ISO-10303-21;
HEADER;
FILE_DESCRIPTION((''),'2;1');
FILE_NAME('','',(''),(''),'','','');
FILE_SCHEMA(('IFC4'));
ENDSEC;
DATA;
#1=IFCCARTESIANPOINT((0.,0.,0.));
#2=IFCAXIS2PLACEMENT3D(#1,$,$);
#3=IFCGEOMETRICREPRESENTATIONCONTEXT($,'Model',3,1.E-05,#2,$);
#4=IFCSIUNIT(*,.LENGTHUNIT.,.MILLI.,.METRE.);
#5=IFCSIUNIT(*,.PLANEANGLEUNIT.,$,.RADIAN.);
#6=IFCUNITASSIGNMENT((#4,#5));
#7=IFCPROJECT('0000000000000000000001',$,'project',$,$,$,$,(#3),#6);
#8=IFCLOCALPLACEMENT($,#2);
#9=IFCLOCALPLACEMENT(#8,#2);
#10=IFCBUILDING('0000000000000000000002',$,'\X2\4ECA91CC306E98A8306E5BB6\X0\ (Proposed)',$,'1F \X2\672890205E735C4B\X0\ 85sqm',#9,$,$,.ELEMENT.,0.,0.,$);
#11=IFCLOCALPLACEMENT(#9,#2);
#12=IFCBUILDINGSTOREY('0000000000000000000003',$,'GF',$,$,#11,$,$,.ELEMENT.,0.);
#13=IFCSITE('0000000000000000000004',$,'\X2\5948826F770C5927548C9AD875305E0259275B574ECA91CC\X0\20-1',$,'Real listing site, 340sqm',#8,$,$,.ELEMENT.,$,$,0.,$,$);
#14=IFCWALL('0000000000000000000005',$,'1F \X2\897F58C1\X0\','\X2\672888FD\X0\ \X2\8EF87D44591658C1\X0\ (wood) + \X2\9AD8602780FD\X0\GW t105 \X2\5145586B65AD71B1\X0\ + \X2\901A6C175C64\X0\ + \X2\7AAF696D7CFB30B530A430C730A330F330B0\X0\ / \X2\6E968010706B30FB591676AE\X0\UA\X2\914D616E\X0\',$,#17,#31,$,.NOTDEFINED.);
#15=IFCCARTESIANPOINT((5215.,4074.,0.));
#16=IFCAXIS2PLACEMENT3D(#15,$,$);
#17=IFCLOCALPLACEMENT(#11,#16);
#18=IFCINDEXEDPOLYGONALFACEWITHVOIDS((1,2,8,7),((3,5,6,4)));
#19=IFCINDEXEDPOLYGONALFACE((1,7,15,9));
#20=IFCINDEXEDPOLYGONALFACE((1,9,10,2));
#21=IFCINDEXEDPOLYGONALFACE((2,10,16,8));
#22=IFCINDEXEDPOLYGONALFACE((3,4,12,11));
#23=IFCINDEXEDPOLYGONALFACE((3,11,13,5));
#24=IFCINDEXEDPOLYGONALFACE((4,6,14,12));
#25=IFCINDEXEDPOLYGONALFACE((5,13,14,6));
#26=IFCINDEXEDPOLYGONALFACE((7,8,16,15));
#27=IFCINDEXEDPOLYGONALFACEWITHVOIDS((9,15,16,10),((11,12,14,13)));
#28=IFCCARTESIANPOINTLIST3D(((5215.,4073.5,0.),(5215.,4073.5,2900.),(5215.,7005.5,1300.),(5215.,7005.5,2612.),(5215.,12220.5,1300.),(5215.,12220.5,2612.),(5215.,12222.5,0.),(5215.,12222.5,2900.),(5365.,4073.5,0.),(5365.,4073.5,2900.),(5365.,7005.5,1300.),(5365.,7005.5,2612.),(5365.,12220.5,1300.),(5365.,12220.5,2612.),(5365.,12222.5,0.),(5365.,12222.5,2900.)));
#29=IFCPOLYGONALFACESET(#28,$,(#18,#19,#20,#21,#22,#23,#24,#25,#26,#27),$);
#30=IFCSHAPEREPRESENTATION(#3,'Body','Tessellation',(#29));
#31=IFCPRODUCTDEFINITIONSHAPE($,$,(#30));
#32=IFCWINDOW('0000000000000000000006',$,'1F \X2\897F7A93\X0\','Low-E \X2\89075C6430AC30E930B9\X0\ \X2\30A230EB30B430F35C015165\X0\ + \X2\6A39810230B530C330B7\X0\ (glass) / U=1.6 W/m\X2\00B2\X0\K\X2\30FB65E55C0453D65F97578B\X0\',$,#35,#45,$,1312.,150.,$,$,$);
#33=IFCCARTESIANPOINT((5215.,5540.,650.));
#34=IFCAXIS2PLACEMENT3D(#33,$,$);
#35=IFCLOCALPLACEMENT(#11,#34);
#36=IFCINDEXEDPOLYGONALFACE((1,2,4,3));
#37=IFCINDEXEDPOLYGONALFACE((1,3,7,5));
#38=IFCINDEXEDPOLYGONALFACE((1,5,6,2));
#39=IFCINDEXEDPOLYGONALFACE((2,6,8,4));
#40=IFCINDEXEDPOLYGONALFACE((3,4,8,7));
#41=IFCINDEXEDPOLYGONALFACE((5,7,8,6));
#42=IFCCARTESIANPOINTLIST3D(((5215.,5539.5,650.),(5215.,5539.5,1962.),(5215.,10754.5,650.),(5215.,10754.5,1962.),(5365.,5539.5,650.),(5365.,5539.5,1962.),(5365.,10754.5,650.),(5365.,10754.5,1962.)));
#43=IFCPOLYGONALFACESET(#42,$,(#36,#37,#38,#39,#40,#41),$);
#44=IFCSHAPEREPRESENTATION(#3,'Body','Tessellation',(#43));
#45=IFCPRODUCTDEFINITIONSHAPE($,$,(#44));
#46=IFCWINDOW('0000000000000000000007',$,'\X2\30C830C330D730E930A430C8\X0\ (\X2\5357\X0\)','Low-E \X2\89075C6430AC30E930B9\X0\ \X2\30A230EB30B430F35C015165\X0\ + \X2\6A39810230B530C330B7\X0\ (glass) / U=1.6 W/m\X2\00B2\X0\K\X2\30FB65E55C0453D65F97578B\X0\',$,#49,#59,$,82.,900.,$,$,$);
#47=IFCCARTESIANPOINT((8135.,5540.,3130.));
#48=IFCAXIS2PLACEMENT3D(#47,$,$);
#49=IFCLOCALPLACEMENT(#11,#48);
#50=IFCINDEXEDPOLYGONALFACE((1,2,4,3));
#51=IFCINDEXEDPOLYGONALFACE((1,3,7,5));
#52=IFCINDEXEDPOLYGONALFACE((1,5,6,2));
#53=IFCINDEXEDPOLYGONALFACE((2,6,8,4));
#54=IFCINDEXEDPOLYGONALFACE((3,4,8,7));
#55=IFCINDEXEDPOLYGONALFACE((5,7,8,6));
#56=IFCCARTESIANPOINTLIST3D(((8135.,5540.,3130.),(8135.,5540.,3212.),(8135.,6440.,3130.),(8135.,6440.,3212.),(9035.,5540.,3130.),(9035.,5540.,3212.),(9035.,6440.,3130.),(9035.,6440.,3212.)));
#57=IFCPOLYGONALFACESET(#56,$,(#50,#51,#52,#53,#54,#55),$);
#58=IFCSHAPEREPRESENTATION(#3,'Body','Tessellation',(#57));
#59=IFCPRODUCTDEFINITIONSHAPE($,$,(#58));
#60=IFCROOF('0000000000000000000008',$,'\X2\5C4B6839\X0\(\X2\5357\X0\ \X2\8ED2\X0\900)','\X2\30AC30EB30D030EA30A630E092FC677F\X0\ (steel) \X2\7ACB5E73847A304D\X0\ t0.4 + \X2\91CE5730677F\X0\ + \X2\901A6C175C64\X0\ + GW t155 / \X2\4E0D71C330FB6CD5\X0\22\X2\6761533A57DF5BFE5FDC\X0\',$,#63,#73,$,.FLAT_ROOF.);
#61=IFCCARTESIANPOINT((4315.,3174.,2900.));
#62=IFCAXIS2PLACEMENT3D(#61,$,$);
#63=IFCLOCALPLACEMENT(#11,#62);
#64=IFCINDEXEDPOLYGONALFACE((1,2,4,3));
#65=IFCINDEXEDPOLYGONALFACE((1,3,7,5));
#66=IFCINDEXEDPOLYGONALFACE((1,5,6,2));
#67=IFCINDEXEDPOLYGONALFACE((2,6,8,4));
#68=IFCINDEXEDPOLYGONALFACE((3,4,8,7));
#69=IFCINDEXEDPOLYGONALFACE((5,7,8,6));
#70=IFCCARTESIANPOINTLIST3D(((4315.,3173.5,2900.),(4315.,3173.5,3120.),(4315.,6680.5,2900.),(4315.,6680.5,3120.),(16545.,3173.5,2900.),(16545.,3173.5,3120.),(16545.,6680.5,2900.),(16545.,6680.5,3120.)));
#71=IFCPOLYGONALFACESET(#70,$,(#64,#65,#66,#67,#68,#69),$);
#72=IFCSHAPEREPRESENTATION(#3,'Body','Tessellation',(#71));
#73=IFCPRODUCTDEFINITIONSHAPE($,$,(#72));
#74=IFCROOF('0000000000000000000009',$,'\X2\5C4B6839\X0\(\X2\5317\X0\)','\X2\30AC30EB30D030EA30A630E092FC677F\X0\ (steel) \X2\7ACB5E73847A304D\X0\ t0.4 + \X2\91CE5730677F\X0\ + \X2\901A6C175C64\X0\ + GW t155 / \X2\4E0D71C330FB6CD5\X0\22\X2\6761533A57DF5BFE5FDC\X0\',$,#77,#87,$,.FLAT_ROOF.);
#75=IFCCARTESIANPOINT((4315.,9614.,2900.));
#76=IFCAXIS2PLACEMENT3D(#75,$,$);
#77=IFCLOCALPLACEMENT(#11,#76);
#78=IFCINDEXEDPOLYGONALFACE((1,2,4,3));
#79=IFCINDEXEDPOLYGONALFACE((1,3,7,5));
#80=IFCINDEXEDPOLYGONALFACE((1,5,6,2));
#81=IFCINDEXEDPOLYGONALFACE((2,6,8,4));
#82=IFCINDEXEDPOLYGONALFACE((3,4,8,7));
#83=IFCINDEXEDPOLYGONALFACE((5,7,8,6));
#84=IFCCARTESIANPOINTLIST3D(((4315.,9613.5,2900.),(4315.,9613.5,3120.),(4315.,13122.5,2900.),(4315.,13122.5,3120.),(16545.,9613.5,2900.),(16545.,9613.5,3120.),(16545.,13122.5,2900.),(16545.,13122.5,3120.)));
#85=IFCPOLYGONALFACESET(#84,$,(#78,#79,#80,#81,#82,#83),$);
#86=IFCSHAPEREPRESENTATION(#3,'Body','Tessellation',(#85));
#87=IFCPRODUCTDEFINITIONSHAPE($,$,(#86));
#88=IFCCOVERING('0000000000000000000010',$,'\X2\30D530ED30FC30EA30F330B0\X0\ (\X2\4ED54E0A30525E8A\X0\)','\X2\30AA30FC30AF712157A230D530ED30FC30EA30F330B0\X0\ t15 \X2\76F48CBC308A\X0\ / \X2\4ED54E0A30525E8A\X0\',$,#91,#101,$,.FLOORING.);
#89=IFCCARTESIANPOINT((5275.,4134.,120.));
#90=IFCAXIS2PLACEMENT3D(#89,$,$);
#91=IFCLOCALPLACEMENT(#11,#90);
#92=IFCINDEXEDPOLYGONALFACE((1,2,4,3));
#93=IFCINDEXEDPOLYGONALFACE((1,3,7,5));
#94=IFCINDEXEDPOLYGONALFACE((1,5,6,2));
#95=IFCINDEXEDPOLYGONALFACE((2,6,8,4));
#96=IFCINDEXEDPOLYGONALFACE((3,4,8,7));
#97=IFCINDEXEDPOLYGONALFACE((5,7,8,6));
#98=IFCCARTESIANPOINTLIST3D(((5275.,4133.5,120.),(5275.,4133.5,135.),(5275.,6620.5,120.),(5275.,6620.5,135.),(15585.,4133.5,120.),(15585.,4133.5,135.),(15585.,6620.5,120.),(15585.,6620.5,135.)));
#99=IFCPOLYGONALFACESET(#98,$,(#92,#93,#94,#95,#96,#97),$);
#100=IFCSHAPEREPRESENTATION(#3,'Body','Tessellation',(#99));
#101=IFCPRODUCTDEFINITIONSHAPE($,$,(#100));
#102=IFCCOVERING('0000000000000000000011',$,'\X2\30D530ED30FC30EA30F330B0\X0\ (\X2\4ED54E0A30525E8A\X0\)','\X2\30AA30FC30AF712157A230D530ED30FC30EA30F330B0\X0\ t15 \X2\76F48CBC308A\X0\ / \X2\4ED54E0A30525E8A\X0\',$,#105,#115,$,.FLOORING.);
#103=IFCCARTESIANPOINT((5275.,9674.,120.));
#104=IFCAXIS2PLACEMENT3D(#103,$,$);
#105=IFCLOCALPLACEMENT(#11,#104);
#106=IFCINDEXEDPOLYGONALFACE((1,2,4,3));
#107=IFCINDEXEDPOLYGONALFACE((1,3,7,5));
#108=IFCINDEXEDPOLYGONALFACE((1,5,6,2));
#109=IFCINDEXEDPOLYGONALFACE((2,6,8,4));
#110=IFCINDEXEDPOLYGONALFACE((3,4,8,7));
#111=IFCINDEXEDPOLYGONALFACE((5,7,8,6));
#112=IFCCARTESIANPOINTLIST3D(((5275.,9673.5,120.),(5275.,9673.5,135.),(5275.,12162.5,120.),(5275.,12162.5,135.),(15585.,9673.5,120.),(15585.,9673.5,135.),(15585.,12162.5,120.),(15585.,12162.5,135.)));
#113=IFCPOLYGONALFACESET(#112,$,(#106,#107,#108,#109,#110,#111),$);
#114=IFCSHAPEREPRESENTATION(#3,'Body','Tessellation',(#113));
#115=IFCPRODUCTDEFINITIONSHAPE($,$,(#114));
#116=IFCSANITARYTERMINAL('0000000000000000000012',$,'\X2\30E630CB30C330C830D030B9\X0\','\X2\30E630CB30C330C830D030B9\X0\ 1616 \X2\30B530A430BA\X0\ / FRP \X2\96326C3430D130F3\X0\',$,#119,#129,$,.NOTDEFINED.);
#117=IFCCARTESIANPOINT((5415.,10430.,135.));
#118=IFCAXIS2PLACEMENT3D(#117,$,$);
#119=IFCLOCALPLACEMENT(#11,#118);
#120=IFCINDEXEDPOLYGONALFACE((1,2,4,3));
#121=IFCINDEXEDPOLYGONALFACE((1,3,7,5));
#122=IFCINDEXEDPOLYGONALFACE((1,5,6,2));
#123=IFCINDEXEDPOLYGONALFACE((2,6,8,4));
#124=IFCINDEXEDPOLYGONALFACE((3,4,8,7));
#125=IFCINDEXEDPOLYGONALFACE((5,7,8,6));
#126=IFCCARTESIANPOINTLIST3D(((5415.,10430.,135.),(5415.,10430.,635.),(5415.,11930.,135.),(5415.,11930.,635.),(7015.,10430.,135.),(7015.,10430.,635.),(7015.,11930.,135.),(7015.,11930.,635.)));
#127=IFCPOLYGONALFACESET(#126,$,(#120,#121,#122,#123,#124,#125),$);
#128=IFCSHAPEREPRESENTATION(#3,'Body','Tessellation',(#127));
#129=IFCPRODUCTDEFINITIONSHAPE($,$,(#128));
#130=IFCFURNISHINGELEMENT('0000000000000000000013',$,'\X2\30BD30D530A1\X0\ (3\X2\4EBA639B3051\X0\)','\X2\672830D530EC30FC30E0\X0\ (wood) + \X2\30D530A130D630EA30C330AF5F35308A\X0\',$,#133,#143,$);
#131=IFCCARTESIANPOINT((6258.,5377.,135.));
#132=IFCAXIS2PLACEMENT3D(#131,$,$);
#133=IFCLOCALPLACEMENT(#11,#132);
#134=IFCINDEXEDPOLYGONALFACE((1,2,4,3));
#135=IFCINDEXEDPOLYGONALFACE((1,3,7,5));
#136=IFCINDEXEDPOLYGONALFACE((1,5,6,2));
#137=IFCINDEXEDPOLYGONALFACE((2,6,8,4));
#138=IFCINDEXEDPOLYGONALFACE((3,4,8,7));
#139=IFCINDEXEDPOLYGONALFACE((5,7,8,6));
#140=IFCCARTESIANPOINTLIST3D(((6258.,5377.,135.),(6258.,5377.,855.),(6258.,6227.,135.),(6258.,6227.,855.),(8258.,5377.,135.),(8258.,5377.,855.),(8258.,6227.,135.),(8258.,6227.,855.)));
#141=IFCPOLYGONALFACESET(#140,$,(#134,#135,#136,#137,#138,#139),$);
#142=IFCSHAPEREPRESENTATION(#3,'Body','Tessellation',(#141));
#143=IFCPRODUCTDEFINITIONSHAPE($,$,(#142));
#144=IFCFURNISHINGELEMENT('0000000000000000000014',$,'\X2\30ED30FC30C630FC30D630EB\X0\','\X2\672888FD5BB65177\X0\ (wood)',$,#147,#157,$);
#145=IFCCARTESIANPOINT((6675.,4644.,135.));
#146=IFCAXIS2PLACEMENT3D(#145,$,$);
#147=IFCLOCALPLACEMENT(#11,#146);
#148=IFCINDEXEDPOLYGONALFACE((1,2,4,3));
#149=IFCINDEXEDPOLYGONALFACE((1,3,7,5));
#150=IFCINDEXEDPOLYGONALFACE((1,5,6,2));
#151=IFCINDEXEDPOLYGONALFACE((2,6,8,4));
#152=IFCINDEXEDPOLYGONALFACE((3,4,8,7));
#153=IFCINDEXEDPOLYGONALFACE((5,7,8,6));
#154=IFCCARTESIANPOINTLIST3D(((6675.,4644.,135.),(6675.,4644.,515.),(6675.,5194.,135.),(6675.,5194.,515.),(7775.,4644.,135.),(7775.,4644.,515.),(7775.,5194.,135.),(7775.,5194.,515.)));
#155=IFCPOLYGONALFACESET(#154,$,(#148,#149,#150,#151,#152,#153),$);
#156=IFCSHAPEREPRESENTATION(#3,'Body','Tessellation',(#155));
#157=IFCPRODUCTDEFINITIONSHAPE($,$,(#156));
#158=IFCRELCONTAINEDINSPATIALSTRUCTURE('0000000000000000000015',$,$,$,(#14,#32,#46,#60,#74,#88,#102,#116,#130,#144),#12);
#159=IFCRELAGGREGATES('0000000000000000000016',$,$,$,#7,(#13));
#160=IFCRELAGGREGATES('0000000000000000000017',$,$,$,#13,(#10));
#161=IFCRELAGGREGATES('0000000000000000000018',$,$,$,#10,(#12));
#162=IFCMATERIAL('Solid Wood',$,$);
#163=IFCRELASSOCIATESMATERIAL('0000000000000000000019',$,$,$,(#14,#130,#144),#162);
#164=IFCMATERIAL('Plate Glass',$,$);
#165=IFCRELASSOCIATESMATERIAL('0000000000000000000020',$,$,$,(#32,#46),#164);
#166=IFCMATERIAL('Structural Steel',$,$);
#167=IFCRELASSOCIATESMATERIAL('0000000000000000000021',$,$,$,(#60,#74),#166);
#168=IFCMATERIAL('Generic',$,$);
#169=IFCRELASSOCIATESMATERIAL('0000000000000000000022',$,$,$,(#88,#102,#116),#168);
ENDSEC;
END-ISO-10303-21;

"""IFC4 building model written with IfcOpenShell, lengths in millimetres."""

from ifc_helpers import new_model, si_unit, frame, frame_2d, origin, place, context, project, spatial, rectangle, extrude, material, element, fill, save


model = new_model("IFC4")

# Units and contexts
model_context = context("Model", 3, precision=1e-05, world=origin())
ifc_project = project(units=[si_unit("LENGTHUNIT", "METRE", prefix="MILLI"), si_unit("PLANEANGLEUNIT", "RADIAN")], contexts=[model_context])

# Site, building, storey
site_placement = place(None, origin())
site = spatial("IfcSite", under=ifc_project, at=site_placement, Name="奈良県大和高田市大字今里20-1", ObjectType="Real listing site, 340sqm", CompositionType="ELEMENT", RefElevation=0.0)
building_placement = place(site_placement, origin())
building = spatial("IfcBuilding", under=site, at=building_placement, Name="今里の風の家 (Proposed)", ObjectType="1F 木造平屋 85sqm", CompositionType="ELEMENT", ElevationOfRefHeight=0.0, ElevationOfTerrain=0.0)
storey_placement = place(building_placement, origin())
storey = spatial("IfcBuildingStorey", under=building, at=storey_placement, Name="GF", CompositionType="ELEMENT", Elevation=0.0)

# Shared definitions
ifc_material_1 = material(Name="Solid Wood")

# Shared definitions
ifc_material_2 = material(Name="Plate Glass")

# Wall, opening, window
wall_1_placement = place(storey_placement, frame((5215.0, 4074.0, 0.0)))
wall_1 = element("IfcWall", 1, at=wall_1_placement, inside=storey, material=ifc_material_1, Name="1F 西壁", Description="木製 軸組外壁 (wood) + 高性能GW t105 充填断熱 + 通気層 + 窯業系サイディング / 準耐火・外皮UA配慮", PredefinedType="NOTDEFINED", context=model_context, shape_type="SweptSolid", body=[
    extrude(rectangle(XDim=150.0, YDim=8149.0, at=frame_2d((75.0, 4074.0))), frame((5215.0, 4074.0, 0.0)), (0.0, 0.0, 1.0), 2900.0),
])
opening_1_placement = place(storey_placement, frame((5215.0, 5540.0, 650.0)))
opening_1 = element("IfcOpeningElement", 2, at=opening_1_placement, cuts=wall_1, PredefinedType="NOTDEFINED", context=model_context, shape_type="SweptSolid", body=[
    extrude(rectangle(XDim=150.0, YDim=5215.0, at=frame_2d((75.0, 2607.0))), frame((5215.0, 5540.0, 650.0)), (0.0, 0.0, 1.0), 1312.0),
])
window_1_placement = place(storey_placement, frame((5215.0, 5540.0, 650.0)))
window_1 = element("IfcWindow", 3, at=window_1_placement, inside=storey, material=ifc_material_2, Name="1F 西窓", Description="Low-E 複層ガラス アルゴン封入 + 樹脂サッシ (glass) / U=1.6 W/m²K・日射取得型", OverallHeight=1312.0, OverallWidth=150.0, context=model_context, shape_type="SweptSolid", body=[
    extrude(rectangle(XDim=150.0, YDim=5215.0, at=frame_2d((75.0, 2607.0))), frame((5215.0, 5540.0, 650.0)), (0.0, 0.0, 1.0), 1312.0),
])
fill(opening_1, window_1)

# Window
window_2_placement = place(storey_placement, frame((8135.0, 5540.0, 3130.0)))
element("IfcWindow", 4, at=window_2_placement, inside=storey, material=ifc_material_2, Name="トップライト (南)", Description="Low-E 複層ガラス アルゴン封入 + 樹脂サッシ (glass) / U=1.6 W/m²K・日射取得型", OverallHeight=82.0, OverallWidth=900.0, context=model_context, shape_type="SweptSolid", body=[
    extrude(rectangle(XDim=900.0, YDim=900.0, at=frame_2d((450.0, 450.0))), frame((8135.0, 5540.0, 3130.0)), (0.0, 0.0, 1.0), 82.0),
])

# Roofs
ifc_material_3 = material(Name="Structural Steel")
roof_1_placement = place(storey_placement, frame((4315.0, 3174.0, 2900.0)))
element("IfcRoof", 5, at=roof_1_placement, inside=storey, material=ifc_material_3, Name="屋根(南 軒900)", Description="ガルバリウム鋼板 (steel) 立平葺き t0.4 + 野地板 + 通気層 + GW t155 / 不燃・法22条区域対応", PredefinedType="FLAT_ROOF", context=model_context, shape_type="SweptSolid", body=[
    extrude(rectangle(XDim=12230.0, YDim=3507.0, at=frame_2d((6115.0, 1753.0))), frame((4315.0, 3174.0, 2900.0)), (0.0, 0.0, 1.0), 220.0),
])
roof_2_placement = place(storey_placement, frame((4315.0, 9614.0, 2900.0)))
element("IfcRoof", 6, at=roof_2_placement, inside=storey, material=ifc_material_3, Name="屋根(北)", Description="ガルバリウム鋼板 (steel) 立平葺き t0.4 + 野地板 + 通気層 + GW t155 / 不燃・法22条区域対応", PredefinedType="FLAT_ROOF", context=model_context, shape_type="SweptSolid", body=[
    extrude(rectangle(XDim=12230.0, YDim=3509.0, at=frame_2d((6115.0, 1754.0))), frame((4315.0, 9614.0, 2900.0)), (0.0, 0.0, 1.0), 220.0),
])

# Coverings
ifc_material_4 = material(Name="Generic")
covering_1_placement = place(storey_placement, frame((5275.0, 4134.0, 120.0)))
element("IfcCovering", 7, at=covering_1_placement, inside=storey, material=ifc_material_4, Name="フローリング (仕上げ床)", Description="オーク無垢フローリング t15 直貼り / 仕上げ床", PredefinedType="FLOORING", context=model_context, shape_type="SweptSolid", body=[
    extrude(rectangle(XDim=10310.0, YDim=2487.0, at=frame_2d((5155.0, 1243.0))), frame((5275.0, 4134.0, 120.0)), (0.0, 0.0, 1.0), 15.0),
])
covering_2_placement = place(storey_placement, frame((5275.0, 9674.0, 120.0)))
element("IfcCovering", 8, at=covering_2_placement, inside=storey, material=ifc_material_4, Name="フローリング (仕上げ床)", Description="オーク無垢フローリング t15 直貼り / 仕上げ床", PredefinedType="FLOORING", context=model_context, shape_type="SweptSolid", body=[
    extrude(rectangle(XDim=10310.0, YDim=2489.0, at=frame_2d((5155.0, 1244.0))), frame((5275.0, 9674.0, 120.0)), (0.0, 0.0, 1.0), 15.0),
])

# Sanitary terminal
sanitary_terminal_placement = place(storey_placement, frame((5415.0, 10430.0, 135.0)))
element("IfcSanitaryTerminal", 9, at=sanitary_terminal_placement, inside=storey, material=ifc_material_4, Name="ユニットバス", Description="ユニットバス 1616 サイズ / FRP 防水パン", PredefinedType="NOTDEFINED", context=model_context, shape_type="SweptSolid", body=[
    extrude(rectangle(XDim=1600.0, YDim=1500.0, at=frame_2d((800.0, 750.0))), frame((5415.0, 10430.0, 135.0)), (0.0, 0.0, 1.0), 500.0),
])

# Furnishing elements
furnishing_1_placement = place(storey_placement, frame((6258.0, 5377.0, 135.0)))
element("IfcFurnishingElement", 10, at=furnishing_1_placement, inside=storey, material=ifc_material_1, Name="ソファ (3人掛け)", Description="木フレーム (wood) + ファブリック張り", context=model_context, shape_type="SweptSolid", body=[
    extrude(rectangle(XDim=2000.0, YDim=850.0, at=frame_2d((1000.0, 425.0))), frame((6258.0, 5377.0, 135.0)), (0.0, 0.0, 1.0), 720.0),
])
furnishing_2_placement = place(storey_placement, frame((6675.0, 4644.0, 135.0)))
element("IfcFurnishingElement", 11, at=furnishing_2_placement, inside=storey, material=ifc_material_1, Name="ローテーブル", Description="木製家具 (wood)", context=model_context, shape_type="SweptSolid", body=[
    extrude(rectangle(XDim=1100.0, YDim=550.0, at=frame_2d((550.0, 275.0))), frame((6675.0, 4644.0, 135.0)), (0.0, 0.0, 1.0), 380.0),
])

save(model, "model.ifc")
